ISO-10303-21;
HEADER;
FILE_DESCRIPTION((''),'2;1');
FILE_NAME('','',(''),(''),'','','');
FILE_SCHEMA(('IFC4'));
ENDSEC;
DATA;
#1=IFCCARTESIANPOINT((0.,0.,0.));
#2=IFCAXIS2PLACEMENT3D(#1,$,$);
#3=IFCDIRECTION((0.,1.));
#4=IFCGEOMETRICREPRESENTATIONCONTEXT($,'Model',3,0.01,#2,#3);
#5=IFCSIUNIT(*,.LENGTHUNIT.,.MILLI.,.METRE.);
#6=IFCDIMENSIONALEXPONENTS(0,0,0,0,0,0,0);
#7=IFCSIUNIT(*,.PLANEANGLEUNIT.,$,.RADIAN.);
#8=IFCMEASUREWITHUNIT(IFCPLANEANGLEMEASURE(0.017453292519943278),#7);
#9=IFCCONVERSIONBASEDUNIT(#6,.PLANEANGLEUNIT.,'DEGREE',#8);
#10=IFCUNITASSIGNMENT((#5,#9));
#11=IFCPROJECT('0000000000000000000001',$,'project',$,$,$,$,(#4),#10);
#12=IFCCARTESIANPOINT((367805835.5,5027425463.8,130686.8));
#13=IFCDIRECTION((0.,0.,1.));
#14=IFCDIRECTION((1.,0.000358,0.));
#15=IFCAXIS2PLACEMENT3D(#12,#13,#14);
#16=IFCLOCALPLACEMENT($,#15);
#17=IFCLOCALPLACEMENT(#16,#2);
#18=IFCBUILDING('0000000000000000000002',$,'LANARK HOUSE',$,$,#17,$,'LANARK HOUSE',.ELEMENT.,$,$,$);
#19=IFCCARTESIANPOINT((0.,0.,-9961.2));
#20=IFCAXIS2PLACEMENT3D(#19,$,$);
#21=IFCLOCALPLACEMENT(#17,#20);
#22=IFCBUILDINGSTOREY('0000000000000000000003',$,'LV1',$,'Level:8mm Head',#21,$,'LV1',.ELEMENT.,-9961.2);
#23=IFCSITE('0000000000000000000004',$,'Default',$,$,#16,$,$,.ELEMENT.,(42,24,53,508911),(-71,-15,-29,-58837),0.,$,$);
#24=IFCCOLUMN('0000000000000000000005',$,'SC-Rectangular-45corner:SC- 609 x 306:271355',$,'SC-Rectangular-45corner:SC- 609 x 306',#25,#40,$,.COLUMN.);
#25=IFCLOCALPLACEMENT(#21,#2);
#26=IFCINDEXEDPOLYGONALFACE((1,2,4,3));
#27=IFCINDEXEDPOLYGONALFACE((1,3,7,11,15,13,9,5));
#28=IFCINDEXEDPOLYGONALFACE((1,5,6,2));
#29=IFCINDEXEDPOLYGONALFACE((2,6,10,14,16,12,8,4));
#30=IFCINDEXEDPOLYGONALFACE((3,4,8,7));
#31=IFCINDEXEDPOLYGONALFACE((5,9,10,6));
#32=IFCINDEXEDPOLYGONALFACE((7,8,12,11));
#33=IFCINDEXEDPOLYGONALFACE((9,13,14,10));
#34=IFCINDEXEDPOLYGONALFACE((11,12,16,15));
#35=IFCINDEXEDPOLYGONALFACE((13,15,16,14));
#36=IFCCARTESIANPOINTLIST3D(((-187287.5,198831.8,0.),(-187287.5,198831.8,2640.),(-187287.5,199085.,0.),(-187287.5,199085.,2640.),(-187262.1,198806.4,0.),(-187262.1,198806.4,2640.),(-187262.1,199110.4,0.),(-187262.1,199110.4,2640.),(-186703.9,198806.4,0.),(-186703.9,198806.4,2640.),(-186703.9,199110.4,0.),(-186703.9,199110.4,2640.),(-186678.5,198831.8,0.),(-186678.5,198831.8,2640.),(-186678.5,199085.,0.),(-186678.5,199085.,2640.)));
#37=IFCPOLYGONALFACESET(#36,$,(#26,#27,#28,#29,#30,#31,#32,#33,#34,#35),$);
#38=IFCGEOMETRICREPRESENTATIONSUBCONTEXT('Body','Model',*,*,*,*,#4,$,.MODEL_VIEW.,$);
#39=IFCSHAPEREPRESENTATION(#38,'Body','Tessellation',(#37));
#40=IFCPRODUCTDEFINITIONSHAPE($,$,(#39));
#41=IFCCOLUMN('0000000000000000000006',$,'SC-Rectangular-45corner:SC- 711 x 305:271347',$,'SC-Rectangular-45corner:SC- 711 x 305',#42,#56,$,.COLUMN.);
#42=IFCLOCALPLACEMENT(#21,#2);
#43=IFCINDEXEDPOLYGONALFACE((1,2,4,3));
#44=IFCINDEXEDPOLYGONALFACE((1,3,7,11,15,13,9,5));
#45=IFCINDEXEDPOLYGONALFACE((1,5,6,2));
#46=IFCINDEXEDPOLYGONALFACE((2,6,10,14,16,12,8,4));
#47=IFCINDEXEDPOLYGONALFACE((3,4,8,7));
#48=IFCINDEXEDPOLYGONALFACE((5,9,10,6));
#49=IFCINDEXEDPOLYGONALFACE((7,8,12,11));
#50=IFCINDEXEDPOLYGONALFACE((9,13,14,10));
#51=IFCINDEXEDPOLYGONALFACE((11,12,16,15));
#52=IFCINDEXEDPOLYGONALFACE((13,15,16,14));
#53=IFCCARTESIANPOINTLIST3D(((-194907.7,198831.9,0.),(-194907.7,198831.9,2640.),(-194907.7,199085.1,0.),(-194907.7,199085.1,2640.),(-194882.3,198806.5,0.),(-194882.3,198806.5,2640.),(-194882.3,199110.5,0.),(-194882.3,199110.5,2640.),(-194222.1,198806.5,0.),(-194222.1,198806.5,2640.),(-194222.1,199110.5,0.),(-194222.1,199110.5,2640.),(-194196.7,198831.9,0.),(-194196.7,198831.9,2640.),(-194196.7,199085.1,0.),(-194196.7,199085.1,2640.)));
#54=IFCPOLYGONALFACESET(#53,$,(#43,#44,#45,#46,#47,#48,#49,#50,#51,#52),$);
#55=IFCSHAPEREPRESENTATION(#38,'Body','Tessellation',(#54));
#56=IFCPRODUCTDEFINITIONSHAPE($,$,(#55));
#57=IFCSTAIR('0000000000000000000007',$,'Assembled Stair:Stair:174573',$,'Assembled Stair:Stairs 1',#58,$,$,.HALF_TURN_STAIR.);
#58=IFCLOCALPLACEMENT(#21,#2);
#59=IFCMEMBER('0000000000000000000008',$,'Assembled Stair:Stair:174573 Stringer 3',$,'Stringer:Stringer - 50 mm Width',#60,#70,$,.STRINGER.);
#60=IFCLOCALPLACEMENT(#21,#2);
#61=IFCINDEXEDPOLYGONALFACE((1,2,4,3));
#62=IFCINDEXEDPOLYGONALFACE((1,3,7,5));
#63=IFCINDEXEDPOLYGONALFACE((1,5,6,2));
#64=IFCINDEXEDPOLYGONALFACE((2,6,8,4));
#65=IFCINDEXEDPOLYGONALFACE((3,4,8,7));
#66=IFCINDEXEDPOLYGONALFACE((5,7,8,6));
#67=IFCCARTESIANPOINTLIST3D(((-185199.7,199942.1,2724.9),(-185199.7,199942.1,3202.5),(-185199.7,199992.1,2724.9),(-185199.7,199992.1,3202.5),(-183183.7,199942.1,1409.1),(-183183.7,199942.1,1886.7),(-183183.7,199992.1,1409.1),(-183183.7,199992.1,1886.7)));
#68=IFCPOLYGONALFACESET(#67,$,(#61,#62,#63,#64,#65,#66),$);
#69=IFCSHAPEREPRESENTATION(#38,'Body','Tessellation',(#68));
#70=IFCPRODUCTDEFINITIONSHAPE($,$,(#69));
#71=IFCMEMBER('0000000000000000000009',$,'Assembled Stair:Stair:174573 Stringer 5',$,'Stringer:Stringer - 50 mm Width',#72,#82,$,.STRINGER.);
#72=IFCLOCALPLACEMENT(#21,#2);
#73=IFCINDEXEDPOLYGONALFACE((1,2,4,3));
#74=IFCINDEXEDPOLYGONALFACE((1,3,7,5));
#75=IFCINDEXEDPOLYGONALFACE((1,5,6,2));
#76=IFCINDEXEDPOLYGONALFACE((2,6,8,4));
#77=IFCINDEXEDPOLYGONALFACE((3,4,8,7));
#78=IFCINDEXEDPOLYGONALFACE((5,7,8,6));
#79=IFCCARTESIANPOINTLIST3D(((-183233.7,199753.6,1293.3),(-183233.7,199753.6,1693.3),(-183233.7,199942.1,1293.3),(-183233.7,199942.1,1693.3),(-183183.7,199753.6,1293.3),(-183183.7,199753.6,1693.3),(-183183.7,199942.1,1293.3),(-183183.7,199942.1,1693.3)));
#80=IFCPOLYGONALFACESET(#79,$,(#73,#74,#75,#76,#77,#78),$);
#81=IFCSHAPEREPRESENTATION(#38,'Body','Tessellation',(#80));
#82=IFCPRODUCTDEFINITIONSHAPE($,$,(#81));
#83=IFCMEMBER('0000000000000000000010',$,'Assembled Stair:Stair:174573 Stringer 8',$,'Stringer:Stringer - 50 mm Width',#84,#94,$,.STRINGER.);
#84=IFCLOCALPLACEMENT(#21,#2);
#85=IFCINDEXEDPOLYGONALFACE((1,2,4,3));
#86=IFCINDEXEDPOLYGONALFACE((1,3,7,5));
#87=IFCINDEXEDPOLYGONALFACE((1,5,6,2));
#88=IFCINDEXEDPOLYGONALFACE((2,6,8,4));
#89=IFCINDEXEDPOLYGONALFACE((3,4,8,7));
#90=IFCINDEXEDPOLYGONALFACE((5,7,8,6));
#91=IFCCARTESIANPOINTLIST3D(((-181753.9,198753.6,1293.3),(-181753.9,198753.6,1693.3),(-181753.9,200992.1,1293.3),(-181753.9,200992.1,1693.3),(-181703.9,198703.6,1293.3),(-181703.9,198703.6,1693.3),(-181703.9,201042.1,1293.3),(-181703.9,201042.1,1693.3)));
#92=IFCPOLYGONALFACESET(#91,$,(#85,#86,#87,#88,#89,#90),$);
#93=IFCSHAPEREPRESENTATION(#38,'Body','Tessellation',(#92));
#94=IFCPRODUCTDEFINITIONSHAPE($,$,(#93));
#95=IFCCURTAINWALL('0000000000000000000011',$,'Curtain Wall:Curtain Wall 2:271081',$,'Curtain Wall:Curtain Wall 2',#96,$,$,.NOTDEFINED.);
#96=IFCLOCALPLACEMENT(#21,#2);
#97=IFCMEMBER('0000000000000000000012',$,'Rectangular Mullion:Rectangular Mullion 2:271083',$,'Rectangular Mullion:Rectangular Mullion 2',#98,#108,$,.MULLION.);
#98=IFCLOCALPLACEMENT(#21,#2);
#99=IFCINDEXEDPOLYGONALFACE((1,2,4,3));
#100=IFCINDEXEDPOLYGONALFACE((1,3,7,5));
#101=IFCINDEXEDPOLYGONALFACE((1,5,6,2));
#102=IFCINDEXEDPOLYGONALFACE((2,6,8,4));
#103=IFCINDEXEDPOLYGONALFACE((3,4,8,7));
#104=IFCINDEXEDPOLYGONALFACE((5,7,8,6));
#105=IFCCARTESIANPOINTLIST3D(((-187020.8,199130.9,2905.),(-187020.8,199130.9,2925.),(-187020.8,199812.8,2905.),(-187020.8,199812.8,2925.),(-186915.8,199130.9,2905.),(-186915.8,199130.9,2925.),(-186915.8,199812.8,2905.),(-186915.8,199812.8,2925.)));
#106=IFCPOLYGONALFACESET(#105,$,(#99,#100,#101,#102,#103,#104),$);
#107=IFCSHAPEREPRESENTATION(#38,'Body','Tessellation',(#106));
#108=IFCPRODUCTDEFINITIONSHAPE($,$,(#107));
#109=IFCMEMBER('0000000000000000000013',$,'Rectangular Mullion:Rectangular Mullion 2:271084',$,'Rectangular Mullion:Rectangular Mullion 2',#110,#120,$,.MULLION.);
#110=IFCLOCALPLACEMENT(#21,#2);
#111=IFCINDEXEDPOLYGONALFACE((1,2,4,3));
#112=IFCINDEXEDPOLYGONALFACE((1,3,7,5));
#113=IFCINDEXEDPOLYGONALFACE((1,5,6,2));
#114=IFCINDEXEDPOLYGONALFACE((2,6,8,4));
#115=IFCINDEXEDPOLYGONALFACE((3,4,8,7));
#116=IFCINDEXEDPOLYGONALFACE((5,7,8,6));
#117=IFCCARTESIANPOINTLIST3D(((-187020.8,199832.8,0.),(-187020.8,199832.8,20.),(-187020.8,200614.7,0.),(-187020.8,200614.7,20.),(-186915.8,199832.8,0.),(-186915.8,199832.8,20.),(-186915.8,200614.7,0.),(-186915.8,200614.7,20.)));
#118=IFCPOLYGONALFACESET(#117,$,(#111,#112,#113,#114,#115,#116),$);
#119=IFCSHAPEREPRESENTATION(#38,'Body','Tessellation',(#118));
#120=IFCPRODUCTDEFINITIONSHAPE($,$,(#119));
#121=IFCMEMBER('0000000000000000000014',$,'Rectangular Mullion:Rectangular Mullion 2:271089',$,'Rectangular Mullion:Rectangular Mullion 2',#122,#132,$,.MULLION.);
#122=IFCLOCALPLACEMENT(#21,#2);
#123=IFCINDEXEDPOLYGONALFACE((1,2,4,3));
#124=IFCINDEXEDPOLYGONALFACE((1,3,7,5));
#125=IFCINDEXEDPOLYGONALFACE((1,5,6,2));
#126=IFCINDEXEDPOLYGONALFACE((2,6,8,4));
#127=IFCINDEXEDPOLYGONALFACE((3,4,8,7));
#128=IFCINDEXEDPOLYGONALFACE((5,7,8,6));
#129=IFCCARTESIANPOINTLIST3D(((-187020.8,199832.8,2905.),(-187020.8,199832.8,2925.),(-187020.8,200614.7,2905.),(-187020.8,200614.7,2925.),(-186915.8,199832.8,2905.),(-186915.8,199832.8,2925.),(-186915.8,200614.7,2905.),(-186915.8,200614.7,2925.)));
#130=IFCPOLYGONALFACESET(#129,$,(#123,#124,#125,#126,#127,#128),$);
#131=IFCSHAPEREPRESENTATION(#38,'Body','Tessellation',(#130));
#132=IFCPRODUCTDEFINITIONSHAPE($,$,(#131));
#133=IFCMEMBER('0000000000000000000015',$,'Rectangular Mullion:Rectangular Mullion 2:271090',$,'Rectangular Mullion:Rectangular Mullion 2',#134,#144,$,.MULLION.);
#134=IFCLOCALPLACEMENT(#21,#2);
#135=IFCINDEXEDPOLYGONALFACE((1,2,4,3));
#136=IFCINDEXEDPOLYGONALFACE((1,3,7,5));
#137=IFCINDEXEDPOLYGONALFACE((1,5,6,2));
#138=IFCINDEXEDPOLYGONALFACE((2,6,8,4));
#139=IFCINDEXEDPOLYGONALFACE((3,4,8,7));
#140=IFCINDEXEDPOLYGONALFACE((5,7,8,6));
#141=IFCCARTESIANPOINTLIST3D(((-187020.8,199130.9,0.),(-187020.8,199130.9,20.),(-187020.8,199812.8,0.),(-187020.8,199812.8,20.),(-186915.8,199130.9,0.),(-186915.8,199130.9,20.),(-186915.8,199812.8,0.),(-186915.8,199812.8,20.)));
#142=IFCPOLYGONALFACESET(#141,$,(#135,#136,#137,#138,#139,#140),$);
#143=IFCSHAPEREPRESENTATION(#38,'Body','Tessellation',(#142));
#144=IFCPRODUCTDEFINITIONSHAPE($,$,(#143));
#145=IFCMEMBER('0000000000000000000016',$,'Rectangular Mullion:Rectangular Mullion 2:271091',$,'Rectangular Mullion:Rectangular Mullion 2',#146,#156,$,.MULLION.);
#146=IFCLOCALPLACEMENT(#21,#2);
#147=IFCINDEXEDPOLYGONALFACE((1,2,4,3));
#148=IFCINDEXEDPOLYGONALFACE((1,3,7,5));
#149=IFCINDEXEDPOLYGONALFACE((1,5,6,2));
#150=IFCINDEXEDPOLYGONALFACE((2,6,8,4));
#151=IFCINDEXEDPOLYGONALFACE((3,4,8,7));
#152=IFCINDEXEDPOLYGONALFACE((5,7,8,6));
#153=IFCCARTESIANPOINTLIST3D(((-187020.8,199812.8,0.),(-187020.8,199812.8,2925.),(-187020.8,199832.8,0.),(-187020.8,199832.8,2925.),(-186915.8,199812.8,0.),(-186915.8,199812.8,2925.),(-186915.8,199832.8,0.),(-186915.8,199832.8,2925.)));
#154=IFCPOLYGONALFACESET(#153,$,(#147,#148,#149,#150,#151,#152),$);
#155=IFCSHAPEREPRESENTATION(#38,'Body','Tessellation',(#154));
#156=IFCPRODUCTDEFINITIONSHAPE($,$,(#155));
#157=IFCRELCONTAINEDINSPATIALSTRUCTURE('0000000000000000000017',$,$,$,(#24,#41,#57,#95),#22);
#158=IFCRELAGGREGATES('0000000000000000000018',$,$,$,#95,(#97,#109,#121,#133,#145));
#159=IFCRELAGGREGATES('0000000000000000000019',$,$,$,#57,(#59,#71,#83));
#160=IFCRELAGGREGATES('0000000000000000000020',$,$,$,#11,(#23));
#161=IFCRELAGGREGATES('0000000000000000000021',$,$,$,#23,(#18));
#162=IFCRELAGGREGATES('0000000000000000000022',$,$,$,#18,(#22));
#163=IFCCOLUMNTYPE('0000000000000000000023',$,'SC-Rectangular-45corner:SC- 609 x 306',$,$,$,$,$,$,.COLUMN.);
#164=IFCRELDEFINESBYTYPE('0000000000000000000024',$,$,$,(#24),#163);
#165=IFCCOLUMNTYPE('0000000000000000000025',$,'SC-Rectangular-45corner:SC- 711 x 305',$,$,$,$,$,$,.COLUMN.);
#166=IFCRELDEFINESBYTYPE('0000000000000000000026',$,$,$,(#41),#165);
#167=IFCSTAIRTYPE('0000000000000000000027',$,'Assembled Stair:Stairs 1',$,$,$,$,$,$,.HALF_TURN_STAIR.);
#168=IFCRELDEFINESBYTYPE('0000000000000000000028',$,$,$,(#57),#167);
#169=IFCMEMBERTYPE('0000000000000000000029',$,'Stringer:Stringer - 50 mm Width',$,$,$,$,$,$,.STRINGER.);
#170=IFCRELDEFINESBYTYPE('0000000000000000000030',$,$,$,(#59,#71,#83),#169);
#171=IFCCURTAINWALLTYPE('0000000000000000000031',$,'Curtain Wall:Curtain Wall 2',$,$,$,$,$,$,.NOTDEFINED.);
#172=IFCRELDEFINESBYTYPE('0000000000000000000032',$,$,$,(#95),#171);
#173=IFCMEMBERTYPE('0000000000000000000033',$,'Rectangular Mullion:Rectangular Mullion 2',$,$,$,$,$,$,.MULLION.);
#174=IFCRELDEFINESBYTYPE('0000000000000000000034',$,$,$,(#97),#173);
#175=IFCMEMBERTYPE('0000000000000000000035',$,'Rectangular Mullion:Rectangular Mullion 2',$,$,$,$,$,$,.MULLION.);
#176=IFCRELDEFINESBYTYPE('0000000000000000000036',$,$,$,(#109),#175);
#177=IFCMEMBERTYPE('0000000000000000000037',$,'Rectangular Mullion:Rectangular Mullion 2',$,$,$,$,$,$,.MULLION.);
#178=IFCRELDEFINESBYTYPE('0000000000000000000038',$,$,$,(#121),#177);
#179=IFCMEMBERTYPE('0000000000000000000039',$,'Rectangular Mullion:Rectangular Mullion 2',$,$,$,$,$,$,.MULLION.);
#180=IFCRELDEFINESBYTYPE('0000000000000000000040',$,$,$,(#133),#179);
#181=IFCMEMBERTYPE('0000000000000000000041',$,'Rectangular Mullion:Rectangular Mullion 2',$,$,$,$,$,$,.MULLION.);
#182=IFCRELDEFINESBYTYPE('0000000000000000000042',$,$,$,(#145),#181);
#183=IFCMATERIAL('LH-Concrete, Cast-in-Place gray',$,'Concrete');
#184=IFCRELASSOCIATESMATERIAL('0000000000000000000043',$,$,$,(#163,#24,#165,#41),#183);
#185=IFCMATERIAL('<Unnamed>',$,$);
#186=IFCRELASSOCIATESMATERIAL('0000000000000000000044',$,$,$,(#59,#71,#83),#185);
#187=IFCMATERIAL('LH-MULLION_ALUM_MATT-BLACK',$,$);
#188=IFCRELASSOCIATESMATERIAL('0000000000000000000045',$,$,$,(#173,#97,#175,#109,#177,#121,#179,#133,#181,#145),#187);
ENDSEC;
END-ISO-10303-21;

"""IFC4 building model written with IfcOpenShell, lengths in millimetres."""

from ifc_helpers import new_model, entity, si_unit, converted_unit, direction, frame, origin, place, context, subcontext, project, spatial, indexed_curve, outline, extrude, source, transform, mapped, material, type_object, type_shapes, element, aggregate, save


model = new_model("IFC4")

# Units and contexts
model_context = context("Model", 3, precision=0.01, world=origin(), true_north=direction((0.0, 1.0)))
body_context = subcontext(model_context, "Body", "Model", "MODEL_VIEW")
ifc_project = project(units=[si_unit("LENGTHUNIT", "METRE", prefix="MILLI"), converted_unit("PLANEANGLEUNIT", "DEGREE", entity("IfcPlaneAngleMeasure", 0.017453292519943278), si_unit("PLANEANGLEUNIT", "RADIAN"), dimensions=[0, 0, 0, 0, 0, 0, 0])], contexts=[model_context])

# Site, building, storey
site_placement = place(None, frame((367805835.5, 5027425463.8, 130686.8), z_axis=(0.0, 0.0, 1.0), x_axis=(1.0, 0.000358, 0.0)))
site = spatial("IfcSite", under=ifc_project, at=site_placement, Name="Default", CompositionType="ELEMENT", RefLatitude=(42, 24, 53, 508911), RefLongitude=(-71, -15, -29, -58837), RefElevation=0.0)
building_placement = place(site_placement, origin())
building = spatial("IfcBuilding", under=site, at=building_placement, Name="LANARK HOUSE", LongName="LANARK HOUSE", CompositionType="ELEMENT")
storey_placement = place(building_placement, frame((0.0, 0.0, -9961.2)))
storey = spatial("IfcBuildingStorey", under=building, at=storey_placement, Name="LV1", ObjectType="Level:8mm Head", LongName="LV1", CompositionType="ELEMENT", Elevation=-9961.2)

# Columns
ifc_material_1 = material(Name="LH-Concrete, Cast-in-Place gray", Category="Concrete")
column_type_1 = type_object("IfcColumnType", Name="SC-Rectangular-45corner:SC- 609 x 306", PredefinedType="COLUMN", material=ifc_material_1)
shared_shape_1 = source(origin(), body_context, "Body", "SweptSolid", [
    extrude(outline(indexed_curve([(-279.1, -152.0), (279.1, -152.0), (304.5, -126.6), (304.5, 126.6), (279.1, 152.0), (-279.1, 152.0), (-304.5, 126.6), (-304.5, -126.6), (-279.1, -152.0)], self_intersect=False)), frame((0.0, 0.0, -9961.2), z_axis=(0.0, 0.0, 1.0), x_axis=(-1.0, 0.0, 0.0)), (0.0, 0.0, 1.0), 2640.0),
])
type_shapes(column_type_1, [shared_shape_1])
column_1_placement = place(storey_placement, frame((-186983.0, 198958.4, 9961.2)))
element("IfcColumn", 1, at=column_1_placement, inside=storey, type_object=column_type_1, material=ifc_material_1, Name="SC-Rectangular-45corner:SC- 609 x 306:271355", ObjectType="SC-Rectangular-45corner:SC- 609 x 306", PredefinedType="COLUMN", context=body_context, shape_type="MappedRepresentation", body=[
    mapped(shared_shape_1, transform((0.0, 0.0, 0.0), scale=1.0)),
])
column_type_2 = type_object("IfcColumnType", Name="SC-Rectangular-45corner:SC- 711 x 305", PredefinedType="COLUMN", material=ifc_material_1)
shared_shape_2 = source(origin(), body_context, "Body", "SweptSolid", [
    extrude(outline(indexed_curve([(-330.1, -152.0), (330.1, -152.0), (355.5, -126.6), (355.5, 126.6), (330.1, 152.0), (-330.1, 152.0), (-355.5, 126.6), (-355.5, -126.6), (-330.1, -152.0)], self_intersect=False)), frame((0.0, 0.0, -9961.2), z_axis=(0.0, 0.0, 1.0), x_axis=(-1.0, 0.0, 0.0)), (0.0, 0.0, 1.0), 2640.0),
])
type_shapes(column_type_2, [shared_shape_2])
column_2_placement = place(storey_placement, frame((-194552.2, 198958.5, 9961.2)))
element("IfcColumn", 2, at=column_2_placement, inside=storey, type_object=column_type_2, material=ifc_material_1, Name="SC-Rectangular-45corner:SC- 711 x 305:271347", ObjectType="SC-Rectangular-45corner:SC- 711 x 305", PredefinedType="COLUMN", context=body_context, shape_type="MappedRepresentation", body=[
    mapped(shared_shape_2, transform((0.0, 0.0, 0.0), scale=1.0)),
])

# Stair, members
stair_type = type_object("IfcStairType", Name="Assembled Stair:Stairs 1", PredefinedType="HALF_TURN_STAIR")
stair_placement = place(storey_placement, origin())
stair = element("IfcStair", 3, at=stair_placement, inside=storey, type_object=stair_type, Name="Assembled Stair:Stair:174573", ObjectType="Assembled Stair:Stairs 1", PredefinedType="HALF_TURN_STAIR")
ifc_material_2 = material(Name="<Unnamed>")
member_type_1 = type_object("IfcMemberType", Name="Stringer:Stringer - 50 mm Width", PredefinedType="STRINGER")
member_1_placement = place(stair_placement, frame((-185199.7, 199942.1, 1409.1)))
member_1 = element("IfcMember", 4, at=member_1_placement, type_object=member_type_1, material=ifc_material_2, Name="Assembled Stair:Stair:174573 Stringer 3", ObjectType="Stringer:Stringer - 50 mm Width", PredefinedType="STRINGER", context=body_context, shape_type="SweptSolid", body=[
    extrude(outline(indexed_curve([(-1334.2, -200.0), (1073.2, -200.0), (1334.2, 200.0), (-1073.2, 200.0), (-1334.2, -200.0)], self_intersect=False)), frame((1008.0, 0.0, 896.7), z_axis=(0.0, 1.0, 0.0), x_axis=(-0.837419, 0.0, 0.546561)), (0.0, 0.0, 1.0), 50.0),
])
member_2_placement = place(stair_placement, frame((-183233.7, 199753.6, 1293.3)))
member_2 = element("IfcMember", 5, at=member_2_placement, type_object=member_type_1, material=ifc_material_2, Name="Assembled Stair:Stair:174573 Stringer 5", ObjectType="Stringer:Stringer - 50 mm Width", PredefinedType="STRINGER", context=body_context, shape_type="SweptSolid", body=[
    extrude(outline(indexed_curve([(-94.2, -25.0), (94.2, -25.0), (94.2, 25.0), (-94.2, 25.0), (-94.2, -25.0)], self_intersect=False)), frame((25.0, 94.2, 0.0), z_axis=(0.0, 0.0, 1.0), x_axis=(0.0, -1.0, 0.0)), (0.0, 0.0, 1.0), 400.0),
])
member_3_placement = place(stair_placement, frame((-181753.9, 198703.6, 1293.3)))
member_3 = element("IfcMember", 6, at=member_3_placement, type_object=member_type_1, material=ifc_material_2, Name="Assembled Stair:Stair:174573 Stringer 8", ObjectType="Stringer:Stringer - 50 mm Width", PredefinedType="STRINGER", context=body_context, shape_type="SweptSolid", body=[
    extrude(outline(indexed_curve([(-1169.2, -25.0), (1169.2, -25.0), (1119.2, 25.0), (-1119.2, 25.0), (-1169.2, -25.0)], self_intersect=False)), frame((25.0, 1169.2, 0.0), z_axis=(0.0, 0.0, 1.0), x_axis=(0.0, 1.0, 0.0)), (0.0, 0.0, 1.0), 400.0),
])

# Curtain wall, members
curtain_wall_type = type_object("IfcCurtainWallType", Name="Curtain Wall:Curtain Wall 2", PredefinedType="NOTDEFINED")
curtain_wall_placement = place(storey_placement, frame((0.0, 0.0, 9961.2)))
curtain_wall = element("IfcCurtainWall", 7, at=curtain_wall_placement, inside=storey, type_object=curtain_wall_type, Name="Curtain Wall:Curtain Wall 2:271081", ObjectType="Curtain Wall:Curtain Wall 2", PredefinedType="NOTDEFINED")
ifc_material_3 = material(Name="LH-MULLION_ALUM_MATT-BLACK")
member_type_2 = type_object("IfcMemberType", Name="Rectangular Mullion:Rectangular Mullion 2", PredefinedType="MULLION", material=ifc_material_3)
shared_shape_3 = source(origin(), body_context, "Body", "SweptSolid", [
    extrude(outline(indexed_curve([(-10.0, -52.5), (10.0, -52.5), (10.0, 52.5), (-10.0, 52.5), (-10.0, -52.5)], self_intersect=False)), frame((-10.0, -40.0, -681.9), z_axis=(0.0, 0.0, 1.0), x_axis=(-1.0, 0.0, 0.0)), (0.0, 0.0, 1.0), 681.9),
])
type_shapes(member_type_2, [shared_shape_3])
member_4_placement = place(curtain_wall_placement, frame((-187008.3, 199130.9, -7036.2), z_axis=(0.0, -1.0, 0.0), x_axis=(0.0, 0.0, 1.0)))
member_4 = element("IfcMember", 8, at=member_4_placement, type_object=member_type_2, material=ifc_material_3, Name="Rectangular Mullion:Rectangular Mullion 2:271083", ObjectType="Rectangular Mullion:Rectangular Mullion 2", PredefinedType="MULLION", context=body_context, shape_type="MappedRepresentation", body=[
    mapped(shared_shape_3, transform((0.0, 0.0, 0.0), scale=1.0)),
])
member_type_3 = type_object("IfcMemberType", Name="Rectangular Mullion:Rectangular Mullion 2", PredefinedType="MULLION", material=ifc_material_3)
shared_shape_4 = source(origin(), body_context, "Body", "SweptSolid", [
    extrude(outline(indexed_curve([(-10.0, -52.5), (10.0, -52.5), (10.0, 52.5), (-10.0, 52.5), (-10.0, -52.5)], self_intersect=False)), frame((-10.0, -40.0, -781.9), z_axis=(0.0, 0.0, 1.0), x_axis=(-1.0, 0.0, 0.0)), (0.0, 0.0, 1.0), 781.9),
])
type_shapes(member_type_3, [shared_shape_4])
member_5_placement = place(curtain_wall_placement, frame((-187008.3, 200614.7, -9961.2), z_axis=(0.0, 1.0, 0.0), x_axis=(0.0, 0.0, -1.0)))
member_5 = element("IfcMember", 9, at=member_5_placement, type_object=member_type_3, material=ifc_material_3, Name="Rectangular Mullion:Rectangular Mullion 2:271084", ObjectType="Rectangular Mullion:Rectangular Mullion 2", PredefinedType="MULLION", context=body_context, shape_type="MappedRepresentation", body=[
    mapped(shared_shape_4, transform((0.0, 0.0, 0.0), scale=1.0)),
])
member_type_4 = type_object("IfcMemberType", Name="Rectangular Mullion:Rectangular Mullion 2", PredefinedType="MULLION", material=ifc_material_3)
shared_shape_5 = source(origin(), body_context, "Body", "SweptSolid", [
    extrude(outline(indexed_curve([(-10.0, -52.5), (10.0, -52.5), (10.0, 52.5), (-10.0, 52.5), (-10.0, -52.5)], self_intersect=False)), frame((-10.0, -40.0, -781.9), z_axis=(0.0, 0.0, 1.0), x_axis=(-1.0, 0.0, 0.0)), (0.0, 0.0, 1.0), 781.9),
])
type_shapes(member_type_4, [shared_shape_5])
member_6_placement = place(curtain_wall_placement, frame((-187008.3, 199832.8, -7036.2), z_axis=(0.0, -1.0, 0.0), x_axis=(0.0, 0.0, 1.0)))
member_6 = element("IfcMember", 10, at=member_6_placement, type_object=member_type_4, material=ifc_material_3, Name="Rectangular Mullion:Rectangular Mullion 2:271089", ObjectType="Rectangular Mullion:Rectangular Mullion 2", PredefinedType="MULLION", context=body_context, shape_type="MappedRepresentation", body=[
    mapped(shared_shape_5, transform((0.0, 0.0, 0.0), scale=1.0)),
])
member_type_5 = type_object("IfcMemberType", Name="Rectangular Mullion:Rectangular Mullion 2", PredefinedType="MULLION", material=ifc_material_3)
shared_shape_6 = source(origin(), body_context, "Body", "SweptSolid", [
    extrude(outline(indexed_curve([(-10.0, -52.5), (10.0, -52.5), (10.0, 52.5), (-10.0, 52.5), (-10.0, -52.5)], self_intersect=False)), frame((-10.0, -40.0, -681.9), z_axis=(0.0, 0.0, 1.0), x_axis=(-1.0, 0.0, 0.0)), (0.0, 0.0, 1.0), 681.9),
])
type_shapes(member_type_5, [shared_shape_6])
member_7_placement = place(curtain_wall_placement, frame((-187008.3, 199812.8, -9961.2), z_axis=(0.0, 1.0, 0.0), x_axis=(0.0, 0.0, -1.0)))
member_7 = element("IfcMember", 11, at=member_7_placement, type_object=member_type_5, material=ifc_material_3, Name="Rectangular Mullion:Rectangular Mullion 2:271090", ObjectType="Rectangular Mullion:Rectangular Mullion 2", PredefinedType="MULLION", context=body_context, shape_type="MappedRepresentation", body=[
    mapped(shared_shape_6, transform((0.0, 0.0, 0.0), scale=1.0)),
])
member_type_6 = type_object("IfcMemberType", Name="Rectangular Mullion:Rectangular Mullion 2", PredefinedType="MULLION", material=ifc_material_3)
shared_shape_7 = source(origin(), body_context, "Body", "SweptSolid", [
    extrude(outline(indexed_curve([(-10.0, -52.5), (10.0, -52.5), (10.0, 52.5), (-10.0, 52.5), (-10.0, -52.5)], self_intersect=False)), frame((0.0, -40.0, -2925.0), z_axis=(0.0, 0.0, 1.0), x_axis=(-1.0, 0.0, 0.0)), (0.0, 0.0, 1.0), 2925.0),
])
type_shapes(member_type_6, [shared_shape_7])
member_8_placement = place(curtain_wall_placement, frame((-187008.3, 199822.8, -9961.2), z_axis=(0.0, 0.0, -1.0), x_axis=(0.0, -1.0, 0.0)))
member_8 = element("IfcMember", 12, at=member_8_placement, type_object=member_type_6, material=ifc_material_3, Name="Rectangular Mullion:Rectangular Mullion 2:271091", ObjectType="Rectangular Mullion:Rectangular Mullion 2", PredefinedType="MULLION", context=body_context, shape_type="MappedRepresentation", body=[
    mapped(shared_shape_7, transform((0.0, 0.0, 0.0), scale=1.0)),
])

aggregate(curtain_wall, [member_4, member_5, member_6, member_7, member_8])

aggregate(stair, [member_1, member_2, member_3])

save(model, "model.ifc")
